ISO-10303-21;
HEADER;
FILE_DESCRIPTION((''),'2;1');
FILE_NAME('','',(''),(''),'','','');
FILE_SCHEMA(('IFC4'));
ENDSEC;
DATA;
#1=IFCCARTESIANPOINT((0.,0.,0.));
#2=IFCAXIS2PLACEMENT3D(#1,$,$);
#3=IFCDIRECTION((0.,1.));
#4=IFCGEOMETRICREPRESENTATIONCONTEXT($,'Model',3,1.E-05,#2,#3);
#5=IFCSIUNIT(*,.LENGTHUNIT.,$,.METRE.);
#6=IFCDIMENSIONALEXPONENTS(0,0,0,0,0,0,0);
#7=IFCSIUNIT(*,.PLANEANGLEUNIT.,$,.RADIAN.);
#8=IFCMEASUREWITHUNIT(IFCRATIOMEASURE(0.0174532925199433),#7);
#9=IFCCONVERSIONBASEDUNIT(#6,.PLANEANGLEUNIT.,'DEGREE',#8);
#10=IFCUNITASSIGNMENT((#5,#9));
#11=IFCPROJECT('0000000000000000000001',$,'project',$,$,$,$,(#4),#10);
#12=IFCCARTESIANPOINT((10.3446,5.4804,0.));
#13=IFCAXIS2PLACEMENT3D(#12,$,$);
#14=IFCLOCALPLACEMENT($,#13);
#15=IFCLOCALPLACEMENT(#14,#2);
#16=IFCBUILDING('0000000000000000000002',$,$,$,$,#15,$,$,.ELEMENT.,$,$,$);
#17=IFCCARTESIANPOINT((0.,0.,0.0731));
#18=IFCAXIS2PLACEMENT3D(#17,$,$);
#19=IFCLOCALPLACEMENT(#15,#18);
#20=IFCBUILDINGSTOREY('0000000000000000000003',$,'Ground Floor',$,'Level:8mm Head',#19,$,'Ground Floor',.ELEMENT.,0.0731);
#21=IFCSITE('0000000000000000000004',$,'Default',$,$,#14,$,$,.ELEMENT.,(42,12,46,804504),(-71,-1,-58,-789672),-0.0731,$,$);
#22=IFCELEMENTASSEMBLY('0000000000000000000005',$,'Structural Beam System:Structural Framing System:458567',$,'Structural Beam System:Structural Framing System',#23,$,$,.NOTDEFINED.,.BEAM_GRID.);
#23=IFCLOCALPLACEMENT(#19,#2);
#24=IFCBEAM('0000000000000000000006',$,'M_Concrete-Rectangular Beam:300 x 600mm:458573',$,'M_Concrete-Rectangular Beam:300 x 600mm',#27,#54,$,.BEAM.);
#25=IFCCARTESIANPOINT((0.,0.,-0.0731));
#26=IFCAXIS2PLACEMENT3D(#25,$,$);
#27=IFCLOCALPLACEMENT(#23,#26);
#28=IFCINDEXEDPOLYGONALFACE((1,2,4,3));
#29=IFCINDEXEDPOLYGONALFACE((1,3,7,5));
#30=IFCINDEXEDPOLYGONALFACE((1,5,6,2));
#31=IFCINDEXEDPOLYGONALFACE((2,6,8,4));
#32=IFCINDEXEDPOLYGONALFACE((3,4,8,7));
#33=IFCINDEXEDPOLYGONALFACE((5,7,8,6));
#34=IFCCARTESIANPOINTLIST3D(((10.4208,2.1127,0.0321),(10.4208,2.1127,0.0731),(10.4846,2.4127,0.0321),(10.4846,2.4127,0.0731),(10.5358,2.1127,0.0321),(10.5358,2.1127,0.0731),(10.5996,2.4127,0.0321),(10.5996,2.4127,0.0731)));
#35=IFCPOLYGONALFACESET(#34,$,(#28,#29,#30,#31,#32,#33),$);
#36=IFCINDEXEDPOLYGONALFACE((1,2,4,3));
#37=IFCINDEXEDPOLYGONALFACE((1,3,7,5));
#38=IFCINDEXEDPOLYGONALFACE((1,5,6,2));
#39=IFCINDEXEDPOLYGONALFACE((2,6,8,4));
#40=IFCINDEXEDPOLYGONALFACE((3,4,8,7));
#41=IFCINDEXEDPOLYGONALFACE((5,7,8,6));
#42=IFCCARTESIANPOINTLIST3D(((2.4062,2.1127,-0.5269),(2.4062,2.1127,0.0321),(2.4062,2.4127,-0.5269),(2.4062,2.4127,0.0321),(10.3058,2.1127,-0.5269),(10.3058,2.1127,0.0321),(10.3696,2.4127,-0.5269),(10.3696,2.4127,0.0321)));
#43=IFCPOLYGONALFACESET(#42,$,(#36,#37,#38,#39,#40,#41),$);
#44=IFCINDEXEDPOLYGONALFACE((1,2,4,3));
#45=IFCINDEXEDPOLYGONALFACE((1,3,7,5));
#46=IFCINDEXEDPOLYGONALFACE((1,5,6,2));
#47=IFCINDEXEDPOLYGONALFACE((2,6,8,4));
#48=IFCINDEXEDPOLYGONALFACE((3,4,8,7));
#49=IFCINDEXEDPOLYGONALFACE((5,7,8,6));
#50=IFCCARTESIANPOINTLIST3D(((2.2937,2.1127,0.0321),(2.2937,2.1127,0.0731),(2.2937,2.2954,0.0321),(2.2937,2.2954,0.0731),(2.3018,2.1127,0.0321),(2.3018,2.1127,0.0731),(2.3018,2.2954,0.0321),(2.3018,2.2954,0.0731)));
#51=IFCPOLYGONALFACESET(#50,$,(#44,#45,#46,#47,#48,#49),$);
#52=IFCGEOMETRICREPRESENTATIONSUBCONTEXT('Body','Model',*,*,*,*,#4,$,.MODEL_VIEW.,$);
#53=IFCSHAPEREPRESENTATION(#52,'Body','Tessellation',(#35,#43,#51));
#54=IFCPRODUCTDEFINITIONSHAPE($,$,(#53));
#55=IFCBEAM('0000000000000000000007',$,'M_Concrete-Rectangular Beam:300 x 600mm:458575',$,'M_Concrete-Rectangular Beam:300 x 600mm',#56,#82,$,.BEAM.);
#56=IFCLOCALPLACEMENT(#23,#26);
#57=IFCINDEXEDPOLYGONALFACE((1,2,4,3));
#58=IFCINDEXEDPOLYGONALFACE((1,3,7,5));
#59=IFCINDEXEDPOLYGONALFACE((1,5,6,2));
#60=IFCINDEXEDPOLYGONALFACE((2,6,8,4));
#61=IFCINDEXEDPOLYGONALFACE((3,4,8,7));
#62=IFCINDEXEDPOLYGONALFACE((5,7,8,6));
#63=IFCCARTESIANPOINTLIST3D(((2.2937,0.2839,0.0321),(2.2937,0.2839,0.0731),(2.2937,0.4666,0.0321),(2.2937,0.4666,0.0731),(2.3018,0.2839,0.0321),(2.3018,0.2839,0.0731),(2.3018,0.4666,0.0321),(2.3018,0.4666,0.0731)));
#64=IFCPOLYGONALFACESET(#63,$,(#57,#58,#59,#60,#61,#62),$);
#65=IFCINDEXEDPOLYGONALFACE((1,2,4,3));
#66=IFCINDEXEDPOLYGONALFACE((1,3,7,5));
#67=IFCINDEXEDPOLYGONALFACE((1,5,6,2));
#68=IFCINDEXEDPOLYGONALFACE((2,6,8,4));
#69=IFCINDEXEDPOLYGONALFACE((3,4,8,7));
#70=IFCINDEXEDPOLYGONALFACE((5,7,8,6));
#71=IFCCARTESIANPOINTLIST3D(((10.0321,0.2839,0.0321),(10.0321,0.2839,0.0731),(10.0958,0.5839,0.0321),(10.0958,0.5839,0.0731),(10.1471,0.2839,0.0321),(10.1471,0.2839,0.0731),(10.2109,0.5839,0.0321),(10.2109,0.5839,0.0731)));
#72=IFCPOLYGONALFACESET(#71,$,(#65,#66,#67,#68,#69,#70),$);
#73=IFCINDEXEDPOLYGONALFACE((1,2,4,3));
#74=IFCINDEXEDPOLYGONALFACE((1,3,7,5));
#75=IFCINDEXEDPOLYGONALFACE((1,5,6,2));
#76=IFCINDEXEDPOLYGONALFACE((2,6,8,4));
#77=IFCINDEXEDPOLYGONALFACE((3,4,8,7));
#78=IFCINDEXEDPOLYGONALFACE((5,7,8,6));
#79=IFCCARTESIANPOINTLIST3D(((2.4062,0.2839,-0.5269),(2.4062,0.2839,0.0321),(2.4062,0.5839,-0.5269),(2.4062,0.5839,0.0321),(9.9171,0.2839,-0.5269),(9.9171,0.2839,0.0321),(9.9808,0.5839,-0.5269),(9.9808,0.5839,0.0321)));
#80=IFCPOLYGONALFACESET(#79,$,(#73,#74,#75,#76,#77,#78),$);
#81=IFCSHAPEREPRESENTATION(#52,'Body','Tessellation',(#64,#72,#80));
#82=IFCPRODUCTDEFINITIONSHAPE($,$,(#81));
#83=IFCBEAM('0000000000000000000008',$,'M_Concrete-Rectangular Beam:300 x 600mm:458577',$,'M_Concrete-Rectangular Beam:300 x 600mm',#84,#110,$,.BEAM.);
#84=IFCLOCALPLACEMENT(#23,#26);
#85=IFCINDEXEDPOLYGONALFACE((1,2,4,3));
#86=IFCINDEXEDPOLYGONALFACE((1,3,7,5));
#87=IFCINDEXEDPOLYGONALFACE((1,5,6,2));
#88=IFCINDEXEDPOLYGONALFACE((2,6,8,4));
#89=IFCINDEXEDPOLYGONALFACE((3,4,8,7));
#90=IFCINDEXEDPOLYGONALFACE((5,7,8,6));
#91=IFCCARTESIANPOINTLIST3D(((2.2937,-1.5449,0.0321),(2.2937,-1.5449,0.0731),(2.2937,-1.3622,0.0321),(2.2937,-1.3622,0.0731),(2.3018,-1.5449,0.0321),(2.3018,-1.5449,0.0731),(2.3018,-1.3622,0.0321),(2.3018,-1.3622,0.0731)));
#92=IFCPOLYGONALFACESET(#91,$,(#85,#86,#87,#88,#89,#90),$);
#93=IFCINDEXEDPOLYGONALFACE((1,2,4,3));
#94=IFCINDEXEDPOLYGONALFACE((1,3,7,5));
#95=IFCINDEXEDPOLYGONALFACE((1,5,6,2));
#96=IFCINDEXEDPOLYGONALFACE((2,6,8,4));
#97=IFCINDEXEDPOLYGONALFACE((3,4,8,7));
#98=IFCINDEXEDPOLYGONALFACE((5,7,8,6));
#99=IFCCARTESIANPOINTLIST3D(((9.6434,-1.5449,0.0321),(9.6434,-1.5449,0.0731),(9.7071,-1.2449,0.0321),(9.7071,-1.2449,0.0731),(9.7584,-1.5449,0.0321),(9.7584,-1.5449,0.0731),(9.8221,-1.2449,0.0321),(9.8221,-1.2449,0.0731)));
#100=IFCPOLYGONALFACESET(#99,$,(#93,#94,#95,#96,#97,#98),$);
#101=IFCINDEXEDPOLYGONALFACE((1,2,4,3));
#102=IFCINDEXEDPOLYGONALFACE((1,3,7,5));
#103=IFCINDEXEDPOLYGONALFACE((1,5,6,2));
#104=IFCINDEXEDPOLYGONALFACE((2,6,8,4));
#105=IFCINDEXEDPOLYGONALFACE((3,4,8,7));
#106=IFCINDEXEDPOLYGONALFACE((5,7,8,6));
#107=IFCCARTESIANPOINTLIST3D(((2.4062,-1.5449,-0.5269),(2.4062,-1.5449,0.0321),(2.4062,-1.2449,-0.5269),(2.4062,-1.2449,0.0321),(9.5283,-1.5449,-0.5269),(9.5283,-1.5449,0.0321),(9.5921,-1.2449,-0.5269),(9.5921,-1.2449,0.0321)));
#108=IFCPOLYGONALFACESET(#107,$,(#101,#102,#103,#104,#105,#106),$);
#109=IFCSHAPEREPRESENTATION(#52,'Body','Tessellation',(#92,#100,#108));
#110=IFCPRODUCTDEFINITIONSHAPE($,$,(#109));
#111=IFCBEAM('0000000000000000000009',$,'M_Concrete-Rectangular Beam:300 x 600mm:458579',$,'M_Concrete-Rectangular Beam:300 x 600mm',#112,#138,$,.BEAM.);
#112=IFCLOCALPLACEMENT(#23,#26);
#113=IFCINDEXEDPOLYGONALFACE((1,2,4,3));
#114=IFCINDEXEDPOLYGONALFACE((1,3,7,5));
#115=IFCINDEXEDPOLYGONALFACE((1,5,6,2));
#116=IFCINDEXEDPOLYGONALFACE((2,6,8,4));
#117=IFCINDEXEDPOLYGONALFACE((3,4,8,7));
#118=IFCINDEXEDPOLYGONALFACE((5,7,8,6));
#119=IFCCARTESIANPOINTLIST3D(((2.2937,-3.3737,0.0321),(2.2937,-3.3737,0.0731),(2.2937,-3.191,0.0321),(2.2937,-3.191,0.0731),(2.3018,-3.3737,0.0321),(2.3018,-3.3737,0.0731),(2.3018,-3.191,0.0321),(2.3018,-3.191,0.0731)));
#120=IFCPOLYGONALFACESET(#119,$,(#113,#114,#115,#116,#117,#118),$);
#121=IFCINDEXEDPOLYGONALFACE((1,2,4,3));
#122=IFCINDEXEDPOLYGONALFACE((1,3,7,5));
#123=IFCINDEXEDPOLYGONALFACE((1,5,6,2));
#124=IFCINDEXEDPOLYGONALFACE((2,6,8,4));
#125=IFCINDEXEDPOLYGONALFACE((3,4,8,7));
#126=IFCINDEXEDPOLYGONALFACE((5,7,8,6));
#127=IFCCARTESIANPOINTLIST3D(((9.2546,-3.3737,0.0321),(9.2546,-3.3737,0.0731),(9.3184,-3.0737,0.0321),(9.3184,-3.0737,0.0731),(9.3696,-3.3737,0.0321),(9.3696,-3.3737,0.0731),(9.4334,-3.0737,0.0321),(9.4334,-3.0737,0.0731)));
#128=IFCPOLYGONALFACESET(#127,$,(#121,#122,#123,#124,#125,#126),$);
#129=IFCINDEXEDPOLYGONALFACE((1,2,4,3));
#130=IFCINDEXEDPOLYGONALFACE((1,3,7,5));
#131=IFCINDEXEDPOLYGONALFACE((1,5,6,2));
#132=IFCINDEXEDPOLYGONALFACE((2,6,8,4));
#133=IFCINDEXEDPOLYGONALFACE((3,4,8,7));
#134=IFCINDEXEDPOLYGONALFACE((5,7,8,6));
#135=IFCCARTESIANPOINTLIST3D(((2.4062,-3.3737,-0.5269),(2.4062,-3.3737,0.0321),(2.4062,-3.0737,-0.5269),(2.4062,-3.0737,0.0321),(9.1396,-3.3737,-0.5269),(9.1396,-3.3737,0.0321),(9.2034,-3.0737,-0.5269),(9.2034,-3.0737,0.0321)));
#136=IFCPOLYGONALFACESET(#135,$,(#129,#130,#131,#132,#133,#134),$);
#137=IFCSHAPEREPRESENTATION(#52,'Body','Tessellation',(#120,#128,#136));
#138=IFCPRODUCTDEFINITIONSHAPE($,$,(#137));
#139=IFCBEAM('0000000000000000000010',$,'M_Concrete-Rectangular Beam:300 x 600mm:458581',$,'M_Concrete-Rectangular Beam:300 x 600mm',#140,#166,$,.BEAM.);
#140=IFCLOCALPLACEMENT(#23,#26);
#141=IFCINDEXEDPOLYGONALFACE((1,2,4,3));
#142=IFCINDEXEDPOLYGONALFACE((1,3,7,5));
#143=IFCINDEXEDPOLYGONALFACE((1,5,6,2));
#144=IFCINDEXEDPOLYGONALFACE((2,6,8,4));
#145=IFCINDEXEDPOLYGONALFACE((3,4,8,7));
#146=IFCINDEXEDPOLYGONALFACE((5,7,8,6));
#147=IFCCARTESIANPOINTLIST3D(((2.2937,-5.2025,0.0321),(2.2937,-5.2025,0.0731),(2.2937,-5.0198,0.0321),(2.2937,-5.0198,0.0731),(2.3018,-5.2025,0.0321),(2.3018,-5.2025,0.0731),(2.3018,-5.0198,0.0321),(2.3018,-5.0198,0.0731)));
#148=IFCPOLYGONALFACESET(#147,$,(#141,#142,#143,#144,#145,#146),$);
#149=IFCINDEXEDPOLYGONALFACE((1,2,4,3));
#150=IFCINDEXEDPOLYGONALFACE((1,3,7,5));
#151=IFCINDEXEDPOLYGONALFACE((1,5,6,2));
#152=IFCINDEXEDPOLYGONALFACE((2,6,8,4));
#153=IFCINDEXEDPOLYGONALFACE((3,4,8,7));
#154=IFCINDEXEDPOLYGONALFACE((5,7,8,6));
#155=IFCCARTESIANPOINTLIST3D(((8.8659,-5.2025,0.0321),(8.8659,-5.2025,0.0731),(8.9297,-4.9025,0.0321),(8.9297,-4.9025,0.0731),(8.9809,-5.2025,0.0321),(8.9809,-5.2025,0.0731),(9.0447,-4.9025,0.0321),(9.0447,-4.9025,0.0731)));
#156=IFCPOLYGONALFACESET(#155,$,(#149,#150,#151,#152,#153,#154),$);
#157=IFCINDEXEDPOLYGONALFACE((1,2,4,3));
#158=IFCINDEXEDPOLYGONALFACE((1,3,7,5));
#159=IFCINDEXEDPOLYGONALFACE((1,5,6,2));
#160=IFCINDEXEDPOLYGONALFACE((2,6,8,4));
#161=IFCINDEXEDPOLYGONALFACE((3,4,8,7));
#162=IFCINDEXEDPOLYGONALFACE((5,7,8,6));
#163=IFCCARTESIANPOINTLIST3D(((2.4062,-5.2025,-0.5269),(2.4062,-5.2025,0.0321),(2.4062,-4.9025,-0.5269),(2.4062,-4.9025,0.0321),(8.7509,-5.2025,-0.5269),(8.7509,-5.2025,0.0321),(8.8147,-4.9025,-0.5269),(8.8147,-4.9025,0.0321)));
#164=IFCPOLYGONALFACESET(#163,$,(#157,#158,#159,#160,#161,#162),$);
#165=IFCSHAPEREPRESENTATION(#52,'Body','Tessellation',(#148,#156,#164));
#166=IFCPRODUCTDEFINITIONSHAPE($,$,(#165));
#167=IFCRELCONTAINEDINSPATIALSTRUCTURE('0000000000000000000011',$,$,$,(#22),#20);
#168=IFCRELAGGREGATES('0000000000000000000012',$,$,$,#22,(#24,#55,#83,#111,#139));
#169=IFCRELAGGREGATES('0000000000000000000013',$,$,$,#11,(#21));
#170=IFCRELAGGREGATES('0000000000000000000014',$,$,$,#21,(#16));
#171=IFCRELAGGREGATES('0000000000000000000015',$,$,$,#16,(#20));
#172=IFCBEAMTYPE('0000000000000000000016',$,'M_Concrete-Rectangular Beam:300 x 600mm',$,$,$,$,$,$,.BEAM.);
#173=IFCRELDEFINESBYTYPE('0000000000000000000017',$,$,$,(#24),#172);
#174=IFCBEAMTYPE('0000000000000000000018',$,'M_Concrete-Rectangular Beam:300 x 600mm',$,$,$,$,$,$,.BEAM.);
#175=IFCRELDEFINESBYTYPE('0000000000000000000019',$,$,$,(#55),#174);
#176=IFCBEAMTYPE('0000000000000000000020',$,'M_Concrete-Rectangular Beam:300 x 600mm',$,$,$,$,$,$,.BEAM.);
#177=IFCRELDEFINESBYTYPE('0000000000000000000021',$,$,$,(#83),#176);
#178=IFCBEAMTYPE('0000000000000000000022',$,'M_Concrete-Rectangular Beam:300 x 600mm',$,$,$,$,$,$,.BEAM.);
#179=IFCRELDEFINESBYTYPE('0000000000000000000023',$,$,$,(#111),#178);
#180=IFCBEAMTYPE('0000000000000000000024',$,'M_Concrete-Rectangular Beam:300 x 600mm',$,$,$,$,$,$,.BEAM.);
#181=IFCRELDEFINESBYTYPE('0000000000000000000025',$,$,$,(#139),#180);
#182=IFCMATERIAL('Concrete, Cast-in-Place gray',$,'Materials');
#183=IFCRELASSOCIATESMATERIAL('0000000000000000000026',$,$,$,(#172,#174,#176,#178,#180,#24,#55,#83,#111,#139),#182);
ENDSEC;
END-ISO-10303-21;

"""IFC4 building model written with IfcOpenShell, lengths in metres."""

from ifc_helpers import new_model, entity, si_unit, converted_unit, direction, frame, frame_2d, origin, origin_2d_with_axis, place, context, subcontext, project, spatial, rectangle, extrude, clip, halfspace, source, transform, mapped, material, material_profile, profile_set, profile_usage, type_object, type_shapes, element, aggregate, save


model = new_model("IFC4")

# Units and contexts
model_context = context("Model", 3, precision=1e-05, world=origin(), true_north=direction((0.0, 1.0)))
body_context = subcontext(model_context, "Body", "Model", "MODEL_VIEW")
ifc_project = project(units=[si_unit("LENGTHUNIT", "METRE"), converted_unit("PLANEANGLEUNIT", "DEGREE", entity("IfcRatioMeasure", 0.0174532925199433), si_unit("PLANEANGLEUNIT", "RADIAN"), dimensions=[0, 0, 0, 0, 0, 0, 0])], contexts=[model_context])

# Site, building, storey
site_placement = place(None, frame((10.3446, 5.4804, 0.0)))
site = spatial("IfcSite", under=ifc_project, at=site_placement, Name="Default", CompositionType="ELEMENT", RefLatitude=(42, 12, 46, 804504), RefLongitude=(-71, -1, -58, -789672), RefElevation=-0.0731)
building_placement = place(site_placement, origin())
building = spatial("IfcBuilding", under=site, at=building_placement, CompositionType="ELEMENT")
storey_placement = place(building_placement, frame((0.0, 0.0, 0.0731)))
storey = spatial("IfcBuildingStorey", under=building, at=storey_placement, Name="Ground Floor", ObjectType="Level:8mm Head", LongName="Ground Floor", CompositionType="ELEMENT", Elevation=0.0731)

# Element assembly, beams
ifc_material_1 = material(Name="Concrete, Cast-in-Place gray", Category="Materials")
ifc_material_profile = material_profile(ifc_material_1, rectangle(XDim=0.559, YDim=0.3, at=frame_2d((0.0, 0.0), x_axis=(1.0, 0.0))), Name="300 x 600mm")
ifc_profile_set = profile_set([ifc_material_profile], Name="300 x 600mm")
assembly_1_placement = place(storey_placement, origin())
assembly_1 = element("IfcElementAssembly", 1, at=assembly_1_placement, inside=storey, Name="Structural Beam System:Structural Framing System:458567", ObjectType="Structural Beam System:Structural Framing System", AssemblyPlace="NOTDEFINED", PredefinedType="BEAM_GRID")
ifc_profile_usage_1 = profile_usage(ifc_profile_set, cardinal=8)
beam_type_1 = type_object("IfcBeamType", Name="M_Concrete-Rectangular Beam:300 x 600mm", PredefinedType="BEAM", material=ifc_profile_set)
shared_shape_1 = source(origin(), body_context, "Body", "SweptSolid", [
    clip(clip(extrude(rectangle(XDim=0.041, YDim=0.3, at=origin_2d_with_axis()), frame((10.4208, 2.2627, 0.0526), z_axis=(1.0, 0.0, 0.0), x_axis=(0.0, 0.0, -1.0)), (0.0, 0.0, 1.0), 0.1788), halfspace(frame((10.5418, 2.682, 0.0321), z_axis=(-0.978148, 0.207912, 0.0), x_axis=(0.0, 0.0, 1.0)), False)), halfspace(frame((10.5242, 2.0579, 0.4439), z_axis=(0.978148, -0.207912, 0.0), x_axis=(0.207912, 0.978148, 0.0)), False)),
    clip(extrude(rectangle(XDim=0.559, YDim=0.3, at=frame_2d((0.0, 0.0), x_axis=(1.0, 0.0))), frame((2.4062, 2.2627, -0.2474), z_axis=(1.0, 0.0, 0.0), x_axis=(0.0, 0.0, -1.0)), (0.0, 0.0, 1.0), 7.9634), halfspace(frame((8.6968, -5.457, -2.9893), z_axis=(0.978148, -0.207912, 0.0), x_axis=(-0.207912, -0.978148, 0.0)), False)),
    extrude(rectangle(XDim=0.041, YDim=0.1827, at=frame_2d((0.0, 0.0), x_axis=(1.0, 0.0))), frame((2.2937, 2.2041, 0.0526), z_axis=(1.0, 0.0, 0.0), x_axis=(0.0, 0.0, -1.0)), (0.0, 0.0, 1.0), 0.0082),
])
type_shapes(beam_type_1, [shared_shape_1])
beam_1_placement = place(assembly_1_placement, frame((0.0, 0.0, -0.0731)))
beam_1 = element("IfcBeam", 2, at=beam_1_placement, type_object=beam_type_1, material=ifc_profile_usage_1, Name="M_Concrete-Rectangular Beam:300 x 600mm:458573", ObjectType="M_Concrete-Rectangular Beam:300 x 600mm", PredefinedType="BEAM", context=body_context, shape_type="MappedRepresentation", body=[
    mapped(shared_shape_1, transform((0.0, 0.0, 0.0), scale=1.0)),
])
ifc_profile_usage_2 = profile_usage(ifc_profile_set, cardinal=8)
beam_type_2 = type_object("IfcBeamType", Name="M_Concrete-Rectangular Beam:300 x 600mm", PredefinedType="BEAM", material=ifc_profile_set)
shared_shape_2 = source(origin(), body_context, "Body", "SweptSolid", [
    extrude(rectangle(XDim=0.041, YDim=0.1827, at=frame_2d((0.0, 0.0), x_axis=(1.0, 0.0))), frame((2.2937, 0.3753, 0.0526), z_axis=(1.0, 0.0, 0.0), x_axis=(0.0, 0.0, -1.0)), (0.0, 0.0, 1.0), 0.0082),
    clip(clip(extrude(rectangle(XDim=0.041, YDim=0.3, at=frame_2d((0.0, 0.0), x_axis=(1.0, 0.0))), frame((10.0321, 0.4339, 0.0526), z_axis=(1.0, 0.0, 0.0), x_axis=(0.0, 0.0, -1.0)), (0.0, 0.0, 1.0), 0.1788), halfspace(frame((10.5418, 2.682, 0.0321), z_axis=(-0.978148, 0.207912, 0.0), x_axis=(0.0, 0.0, 1.0)), False)), halfspace(frame((10.1354, 0.2291, 0.4439), z_axis=(0.978148, -0.207912, 0.0), x_axis=(0.207912, 0.978148, 0.0)), False)),
    clip(extrude(rectangle(XDim=0.559, YDim=0.3, at=frame_2d((0.0, 0.0), x_axis=(1.0, 0.0))), frame((2.4062, 0.4339, -0.2474), z_axis=(1.0, 0.0, 0.0), x_axis=(0.0, 0.0, -1.0)), (0.0, 0.0, 1.0), 7.5747), halfspace(frame((8.6968, -5.457, -2.9893), z_axis=(0.978148, -0.207912, 0.0), x_axis=(-0.207912, -0.978148, 0.0)), False)),
])
type_shapes(beam_type_2, [shared_shape_2])
beam_2_placement = place(assembly_1_placement, frame((0.0, 0.0, -0.0731)))
beam_2 = element("IfcBeam", 3, at=beam_2_placement, type_object=beam_type_2, material=ifc_profile_usage_2, Name="M_Concrete-Rectangular Beam:300 x 600mm:458575", ObjectType="M_Concrete-Rectangular Beam:300 x 600mm", PredefinedType="BEAM", context=body_context, shape_type="MappedRepresentation", body=[
    mapped(shared_shape_2, transform((0.0, 0.0, 0.0), scale=1.0)),
])
ifc_profile_usage_3 = profile_usage(ifc_profile_set, cardinal=8)
beam_type_3 = type_object("IfcBeamType", Name="M_Concrete-Rectangular Beam:300 x 600mm", PredefinedType="BEAM", material=ifc_profile_set)
shared_shape_3 = source(origin(), body_context, "Body", "SweptSolid", [
    extrude(rectangle(XDim=0.041, YDim=0.1827, at=frame_2d((0.0, 0.0), x_axis=(1.0, 0.0))), frame((2.2937, -1.4535, 0.0526), z_axis=(1.0, 0.0, 0.0), x_axis=(0.0, 0.0, -1.0)), (0.0, 0.0, 1.0), 0.0082),
    clip(clip(extrude(rectangle(XDim=0.041, YDim=0.3, at=frame_2d((0.0, 0.0), x_axis=(1.0, 0.0))), frame((9.6434, -1.3949, 0.0526), z_axis=(1.0, 0.0, 0.0), x_axis=(0.0, 0.0, -1.0)), (0.0, 0.0, 1.0), 0.1788), halfspace(frame((10.5418, 2.682, 0.0321), z_axis=(-0.978148, 0.207912, 0.0), x_axis=(0.0, 0.0, 1.0)), False)), halfspace(frame((9.7467, -1.5997, 0.4439), z_axis=(0.978148, -0.207912, 0.0), x_axis=(0.207912, 0.978148, 0.0)), False)),
    clip(extrude(rectangle(XDim=0.559, YDim=0.3, at=frame_2d((0.0, 0.0), x_axis=(1.0, 0.0))), frame((2.4062, -1.3949, -0.2474), z_axis=(1.0, 0.0, 0.0), x_axis=(0.0, 0.0, -1.0)), (0.0, 0.0, 1.0), 7.186), halfspace(frame((8.6968, -5.457, -2.9893), z_axis=(0.978148, -0.207912, 0.0), x_axis=(-0.207912, -0.978148, 0.0)), False)),
])
type_shapes(beam_type_3, [shared_shape_3])
beam_3_placement = place(assembly_1_placement, frame((0.0, 0.0, -0.0731)))
beam_3 = element("IfcBeam", 4, at=beam_3_placement, type_object=beam_type_3, material=ifc_profile_usage_3, Name="M_Concrete-Rectangular Beam:300 x 600mm:458577", ObjectType="M_Concrete-Rectangular Beam:300 x 600mm", PredefinedType="BEAM", context=body_context, shape_type="MappedRepresentation", body=[
    mapped(shared_shape_3, transform((0.0, 0.0, 0.0), scale=1.0)),
])
ifc_profile_usage_4 = profile_usage(ifc_profile_set, cardinal=8)
beam_type_4 = type_object("IfcBeamType", Name="M_Concrete-Rectangular Beam:300 x 600mm", PredefinedType="BEAM", material=ifc_profile_set)
shared_shape_4 = source(origin(), body_context, "Body", "SweptSolid", [
    extrude(rectangle(XDim=0.041, YDim=0.1827, at=frame_2d((0.0, 0.0), x_axis=(1.0, 0.0))), frame((2.2937, -3.2823, 0.0526), z_axis=(1.0, 0.0, 0.0), x_axis=(0.0, 0.0, -1.0)), (0.0, 0.0, 1.0), 0.0082),
    clip(clip(extrude(rectangle(XDim=0.041, YDim=0.3, at=frame_2d((0.0, 0.0), x_axis=(1.0, 0.0))), frame((9.2546, -3.2237, 0.0526), z_axis=(1.0, 0.0, 0.0), x_axis=(0.0, 0.0, -1.0)), (0.0, 0.0, 1.0), 0.1788), halfspace(frame((10.5418, 2.682, 0.0321), z_axis=(-0.978148, 0.207912, 0.0), x_axis=(0.0, 0.0, 1.0)), False)), halfspace(frame((9.358, -3.4285, 0.4439), z_axis=(0.978148, -0.207912, 0.0), x_axis=(0.207912, 0.978148, 0.0)), False)),
    clip(extrude(rectangle(XDim=0.559, YDim=0.3, at=frame_2d((0.0, 0.0), x_axis=(1.0, 0.0))), frame((2.4062, -3.2237, -0.2474), z_axis=(1.0, 0.0, 0.0), x_axis=(0.0, 0.0, -1.0)), (0.0, 0.0, 1.0), 6.7972), halfspace(frame((8.6968, -5.457, -2.9893), z_axis=(0.978148, -0.207912, 0.0), x_axis=(-0.207912, -0.978148, 0.0)), False)),
])
type_shapes(beam_type_4, [shared_shape_4])
beam_4_placement = place(assembly_1_placement, frame((0.0, 0.0, -0.0731)))
beam_4 = element("IfcBeam", 5, at=beam_4_placement, type_object=beam_type_4, material=ifc_profile_usage_4, Name="M_Concrete-Rectangular Beam:300 x 600mm:458579", ObjectType="M_Concrete-Rectangular Beam:300 x 600mm", PredefinedType="BEAM", context=body_context, shape_type="MappedRepresentation", body=[
    mapped(shared_shape_4, transform((0.0, 0.0, 0.0), scale=1.0)),
])
ifc_profile_usage_5 = profile_usage(ifc_profile_set, cardinal=8)
beam_type_5 = type_object("IfcBeamType", Name="M_Concrete-Rectangular Beam:300 x 600mm", PredefinedType="BEAM", material=ifc_profile_set)
shared_shape_5 = source(origin(), body_context, "Body", "SweptSolid", [
    extrude(rectangle(XDim=0.041, YDim=0.1827, at=frame_2d((0.0, 0.0), x_axis=(1.0, 0.0))), frame((2.2937, -5.1111, 0.0526), z_axis=(1.0, 0.0, 0.0), x_axis=(0.0, 0.0, -1.0)), (0.0, 0.0, 1.0), 0.0082),
    clip(clip(extrude(rectangle(XDim=0.041, YDim=0.3, at=frame_2d((0.0, 0.0), x_axis=(1.0, 0.0))), frame((8.8659, -5.0525, 0.0526), z_axis=(1.0, 0.0, 0.0), x_axis=(0.0, 0.0, -1.0)), (0.0, 0.0, 1.0), 0.1788), halfspace(frame((10.5418, 2.682, 0.0321), z_axis=(-0.978148, 0.207912, 0.0), x_axis=(0.0, 0.0, 1.0)), False)), halfspace(frame((8.9693, -5.2573, 0.4439), z_axis=(0.978148, -0.207912, 0.0), x_axis=(0.207912, 0.978148, 0.0)), False)),
    clip(extrude(rectangle(XDim=0.559, YDim=0.3, at=frame_2d((0.0, 0.0), x_axis=(1.0, 0.0))), frame((2.4062, -5.0525, -0.2474), z_axis=(1.0, 0.0, 0.0), x_axis=(0.0, 0.0, -1.0)), (0.0, 0.0, 1.0), 6.4085), halfspace(frame((8.6968, -5.457, -2.9893), z_axis=(0.978148, -0.207912, 0.0), x_axis=(-0.207912, -0.978148, 0.0)), False)),
])
type_shapes(beam_type_5, [shared_shape_5])
beam_5_placement = place(assembly_1_placement, frame((0.0, 0.0, -0.0731)))
beam_5 = element("IfcBeam", 6, at=beam_5_placement, type_object=beam_type_5, material=ifc_profile_usage_5, Name="M_Concrete-Rectangular Beam:300 x 600mm:458581", ObjectType="M_Concrete-Rectangular Beam:300 x 600mm", PredefinedType="BEAM", context=body_context, shape_type="MappedRepresentation", body=[
    mapped(shared_shape_5, transform((0.0, 0.0, 0.0), scale=1.0)),
])
aggregate(assembly_1, [beam_1, beam_2, beam_3, beam_4, beam_5])

save(model, "model.ifc")
